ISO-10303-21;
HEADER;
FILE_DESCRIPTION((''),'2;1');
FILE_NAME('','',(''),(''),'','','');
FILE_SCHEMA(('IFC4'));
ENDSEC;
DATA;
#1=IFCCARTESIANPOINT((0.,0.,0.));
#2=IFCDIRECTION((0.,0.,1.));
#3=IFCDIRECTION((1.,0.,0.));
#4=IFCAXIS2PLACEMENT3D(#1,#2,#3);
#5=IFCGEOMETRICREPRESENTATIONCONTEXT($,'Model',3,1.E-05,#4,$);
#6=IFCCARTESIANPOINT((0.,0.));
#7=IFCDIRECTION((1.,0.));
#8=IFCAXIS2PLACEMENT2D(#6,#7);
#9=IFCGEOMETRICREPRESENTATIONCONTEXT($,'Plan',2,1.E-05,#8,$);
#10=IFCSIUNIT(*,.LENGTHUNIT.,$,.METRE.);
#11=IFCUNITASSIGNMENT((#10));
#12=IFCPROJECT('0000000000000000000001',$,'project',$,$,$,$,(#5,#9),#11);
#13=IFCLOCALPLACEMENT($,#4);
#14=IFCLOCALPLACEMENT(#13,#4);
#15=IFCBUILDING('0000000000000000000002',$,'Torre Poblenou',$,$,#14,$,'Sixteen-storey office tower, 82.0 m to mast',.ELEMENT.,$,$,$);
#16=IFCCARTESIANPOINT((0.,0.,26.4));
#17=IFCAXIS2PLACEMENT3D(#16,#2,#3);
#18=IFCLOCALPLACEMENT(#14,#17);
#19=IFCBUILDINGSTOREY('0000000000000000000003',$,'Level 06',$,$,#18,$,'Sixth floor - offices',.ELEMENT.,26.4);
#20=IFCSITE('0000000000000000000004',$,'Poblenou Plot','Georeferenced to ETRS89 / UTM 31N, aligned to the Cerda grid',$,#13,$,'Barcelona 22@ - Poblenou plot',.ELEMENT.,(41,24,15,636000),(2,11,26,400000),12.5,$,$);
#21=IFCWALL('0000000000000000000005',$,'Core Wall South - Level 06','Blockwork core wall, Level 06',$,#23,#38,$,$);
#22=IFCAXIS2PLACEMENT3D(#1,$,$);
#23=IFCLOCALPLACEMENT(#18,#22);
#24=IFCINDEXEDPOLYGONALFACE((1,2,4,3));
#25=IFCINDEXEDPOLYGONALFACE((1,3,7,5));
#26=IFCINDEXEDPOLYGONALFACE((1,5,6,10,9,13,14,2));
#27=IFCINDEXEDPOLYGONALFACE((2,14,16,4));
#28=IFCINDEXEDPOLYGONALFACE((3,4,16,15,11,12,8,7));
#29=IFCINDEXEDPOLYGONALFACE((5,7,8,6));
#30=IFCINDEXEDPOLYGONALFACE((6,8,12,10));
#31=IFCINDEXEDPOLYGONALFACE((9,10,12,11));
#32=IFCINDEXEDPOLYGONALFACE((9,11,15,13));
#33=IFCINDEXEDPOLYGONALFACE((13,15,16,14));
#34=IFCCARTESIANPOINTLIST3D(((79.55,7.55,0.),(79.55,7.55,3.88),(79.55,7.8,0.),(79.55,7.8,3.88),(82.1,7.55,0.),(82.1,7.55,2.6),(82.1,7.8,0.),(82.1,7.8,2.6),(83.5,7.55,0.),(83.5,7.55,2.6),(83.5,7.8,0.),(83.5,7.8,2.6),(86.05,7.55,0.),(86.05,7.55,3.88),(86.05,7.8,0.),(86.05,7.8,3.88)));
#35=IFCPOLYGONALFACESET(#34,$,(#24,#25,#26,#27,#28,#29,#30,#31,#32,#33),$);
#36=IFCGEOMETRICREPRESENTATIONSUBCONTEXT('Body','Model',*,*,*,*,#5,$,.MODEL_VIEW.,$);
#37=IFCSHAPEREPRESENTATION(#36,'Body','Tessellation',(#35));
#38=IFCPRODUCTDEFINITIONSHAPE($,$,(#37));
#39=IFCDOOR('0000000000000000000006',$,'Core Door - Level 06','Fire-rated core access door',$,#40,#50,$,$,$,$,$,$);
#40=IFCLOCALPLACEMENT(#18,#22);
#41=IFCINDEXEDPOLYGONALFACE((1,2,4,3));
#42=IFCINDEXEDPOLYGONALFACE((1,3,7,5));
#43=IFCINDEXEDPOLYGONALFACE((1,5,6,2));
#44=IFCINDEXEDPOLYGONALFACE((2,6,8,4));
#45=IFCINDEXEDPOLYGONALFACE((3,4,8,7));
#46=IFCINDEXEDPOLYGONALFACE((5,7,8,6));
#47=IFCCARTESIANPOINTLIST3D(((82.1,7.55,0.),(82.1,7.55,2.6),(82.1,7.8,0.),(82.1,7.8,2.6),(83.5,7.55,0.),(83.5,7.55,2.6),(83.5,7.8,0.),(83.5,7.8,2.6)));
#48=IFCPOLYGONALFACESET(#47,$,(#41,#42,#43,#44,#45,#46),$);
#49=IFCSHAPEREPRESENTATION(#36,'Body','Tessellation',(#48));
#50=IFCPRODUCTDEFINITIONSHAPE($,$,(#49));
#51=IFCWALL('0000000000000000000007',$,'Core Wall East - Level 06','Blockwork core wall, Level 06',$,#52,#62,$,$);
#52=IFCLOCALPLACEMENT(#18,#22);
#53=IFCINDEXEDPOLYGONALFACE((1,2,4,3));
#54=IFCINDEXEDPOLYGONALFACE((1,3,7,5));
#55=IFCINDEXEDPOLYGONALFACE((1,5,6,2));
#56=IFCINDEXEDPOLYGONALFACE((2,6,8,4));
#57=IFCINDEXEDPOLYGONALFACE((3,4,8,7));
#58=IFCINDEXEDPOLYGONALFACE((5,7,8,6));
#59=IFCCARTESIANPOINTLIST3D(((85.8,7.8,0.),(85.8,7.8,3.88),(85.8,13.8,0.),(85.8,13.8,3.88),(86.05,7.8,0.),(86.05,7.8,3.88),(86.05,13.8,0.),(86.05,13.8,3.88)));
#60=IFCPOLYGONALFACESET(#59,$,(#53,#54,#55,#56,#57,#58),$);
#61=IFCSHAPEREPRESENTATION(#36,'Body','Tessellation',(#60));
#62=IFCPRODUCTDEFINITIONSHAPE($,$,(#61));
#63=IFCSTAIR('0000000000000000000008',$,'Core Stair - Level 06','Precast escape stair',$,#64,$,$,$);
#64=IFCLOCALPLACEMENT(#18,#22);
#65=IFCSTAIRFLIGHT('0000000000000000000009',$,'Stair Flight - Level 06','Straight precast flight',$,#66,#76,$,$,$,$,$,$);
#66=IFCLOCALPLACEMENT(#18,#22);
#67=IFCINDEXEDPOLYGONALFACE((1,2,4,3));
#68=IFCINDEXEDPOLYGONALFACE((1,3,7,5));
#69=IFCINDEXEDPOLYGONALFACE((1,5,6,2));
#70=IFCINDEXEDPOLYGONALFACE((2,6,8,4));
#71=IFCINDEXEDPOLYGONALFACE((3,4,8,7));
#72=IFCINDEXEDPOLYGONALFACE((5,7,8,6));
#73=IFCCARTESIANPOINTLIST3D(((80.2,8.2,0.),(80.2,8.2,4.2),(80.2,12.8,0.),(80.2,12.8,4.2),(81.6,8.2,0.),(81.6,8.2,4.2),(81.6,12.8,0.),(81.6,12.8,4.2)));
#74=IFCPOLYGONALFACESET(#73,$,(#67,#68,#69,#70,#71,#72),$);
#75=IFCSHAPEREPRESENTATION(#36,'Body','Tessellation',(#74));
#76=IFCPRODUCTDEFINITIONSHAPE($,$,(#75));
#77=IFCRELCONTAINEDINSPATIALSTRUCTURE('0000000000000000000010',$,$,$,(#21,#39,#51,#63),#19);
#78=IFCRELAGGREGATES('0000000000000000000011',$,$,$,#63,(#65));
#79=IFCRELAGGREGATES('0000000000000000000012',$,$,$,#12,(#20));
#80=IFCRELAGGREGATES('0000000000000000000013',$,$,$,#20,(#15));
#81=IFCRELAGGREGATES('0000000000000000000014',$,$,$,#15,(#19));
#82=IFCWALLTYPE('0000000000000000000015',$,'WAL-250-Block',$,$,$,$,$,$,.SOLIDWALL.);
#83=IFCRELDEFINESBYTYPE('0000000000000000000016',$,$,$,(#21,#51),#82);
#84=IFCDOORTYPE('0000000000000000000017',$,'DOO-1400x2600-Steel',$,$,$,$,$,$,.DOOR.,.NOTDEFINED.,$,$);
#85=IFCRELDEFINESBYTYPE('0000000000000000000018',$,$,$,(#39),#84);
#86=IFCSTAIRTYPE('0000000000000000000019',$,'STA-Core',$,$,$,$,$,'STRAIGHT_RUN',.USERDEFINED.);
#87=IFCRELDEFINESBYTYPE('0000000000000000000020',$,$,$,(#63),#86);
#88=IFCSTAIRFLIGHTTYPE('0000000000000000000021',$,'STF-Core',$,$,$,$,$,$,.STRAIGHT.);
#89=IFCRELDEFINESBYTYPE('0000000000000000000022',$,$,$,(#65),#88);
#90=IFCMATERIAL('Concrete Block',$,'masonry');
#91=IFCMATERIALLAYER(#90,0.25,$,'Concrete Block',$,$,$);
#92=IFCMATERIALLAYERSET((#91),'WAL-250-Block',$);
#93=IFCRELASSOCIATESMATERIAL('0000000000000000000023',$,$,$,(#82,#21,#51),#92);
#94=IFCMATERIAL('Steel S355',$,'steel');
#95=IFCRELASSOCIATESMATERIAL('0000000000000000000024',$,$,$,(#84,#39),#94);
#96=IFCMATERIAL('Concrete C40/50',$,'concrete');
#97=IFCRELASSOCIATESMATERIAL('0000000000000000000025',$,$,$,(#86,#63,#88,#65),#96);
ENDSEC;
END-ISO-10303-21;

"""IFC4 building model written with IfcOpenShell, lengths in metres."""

from ifc_helpers import new_model, si_unit, frame, origin_with_axes, origin_2d_with_axis, place, context, subcontext, project, spatial, line, indexed_curve, outline, extrude, material, layer, layer_set, layer_usage, type_object, element, fill, aggregate, save


model = new_model("IFC4")

# Units and contexts
model_context = context("Model", 3, precision=1e-05, world=origin_with_axes())
plan_context = context("Plan", 2, precision=1e-05, world=origin_2d_with_axis())
body_context = subcontext(model_context, "Body", "Model", "MODEL_VIEW")
ifc_project = project(units=[si_unit("LENGTHUNIT", "METRE")], contexts=[model_context, plan_context])

# Site, building, storey
site_placement = place(None, origin_with_axes())
site = spatial("IfcSite", under=ifc_project, at=site_placement, Name="Poblenou Plot", Description="Georeferenced to ETRS89 / UTM 31N, aligned to the Cerda grid", LongName="Barcelona 22@ - Poblenou plot", CompositionType="ELEMENT", RefLatitude=(41, 24, 15, 636000), RefLongitude=(2, 11, 26, 400000), RefElevation=12.5)
building_placement = place(site_placement, origin_with_axes())
building = spatial("IfcBuilding", under=site, at=building_placement, Name="Torre Poblenou", LongName="Sixteen-storey office tower, 82.0 m to mast", CompositionType="ELEMENT")
storey_placement = place(building_placement, frame((0.0, 0.0, 26.4), z_axis=(0.0, 0.0, 1.0), x_axis=(1.0, 0.0, 0.0)))
storey = spatial("IfcBuildingStorey", under=building, at=storey_placement, Name="Level 06", LongName="Sixth floor - offices", CompositionType="ELEMENT", Elevation=26.4)

# Shared definitions
ifc_material_1 = material(Name="Concrete C40/50", Category="concrete")

# Wall, opening, door
ifc_material_2 = material(Name="Concrete Block", Category="masonry")
ifc_layer_1 = layer(ifc_material_2, 0.25, Name="Concrete Block")
ifc_layer_set_1 = layer_set([ifc_layer_1], Name="WAL-250-Block")
ifc_layer_usage_1 = layer_usage(ifc_layer_set_1, "AXIS2", "POSITIVE", 0.0)
wall_type = type_object("IfcWallType", Name="WAL-250-Block", PredefinedType="SOLIDWALL", material=ifc_layer_set_1)
wall_1_placement = place(storey_placement, frame((86.05, 7.8, 0.0), z_axis=(0.0, 0.0, 1.0), x_axis=(-1.0, 0.0, 0.0)))
wall_1 = element("IfcWall", 1, at=wall_1_placement, inside=storey, type_object=wall_type, material=ifc_layer_usage_1, Name="Core Wall South - Level 06", Description="Blockwork core wall, Level 06", context=body_context, shape_type="SweptSolid", body=[
    extrude(outline(indexed_curve([(0.0, 0.0), (6.5, 0.0), (6.5, 0.25), (0.0, 0.25)], segments=[line(1, 2, 3, 4, 1)])), origin_with_axes(), (0.0, 0.0, 1.0), 3.88),
])
opening_placement = place(wall_1_placement, frame((2.55, -0.05, 0.0), z_axis=(0.0, 0.0, 1.0), x_axis=(1.0, 0.0, 0.0)))
opening = element("IfcOpeningElement", 2, at=opening_placement, cuts=wall_1, PredefinedType="OPENING", context=body_context, shape_type="SweptSolid", body=[
    extrude(outline(indexed_curve([(0.0, 0.0), (1.4, 0.0), (1.4, 0.35), (0.0, 0.35)], segments=[line(1, 2, 3, 4, 1)])), origin_with_axes(), (0.0, 0.0, 1.0), 2.6),
])
ifc_material_3 = material(Name="Steel S355", Category="steel")
door_type = type_object("IfcDoorType", Name="DOO-1400x2600-Steel", OperationType="NOTDEFINED", PredefinedType="DOOR", material=ifc_material_3)
door_placement = place(storey_placement, frame((83.5, 7.8, 0.0), z_axis=(0.0, 0.0, 1.0), x_axis=(-1.0, 0.0, 0.0)))
door = element("IfcDoor", 3, at=door_placement, inside=storey, type_object=door_type, material=ifc_material_3, Name="Core Door - Level 06", Description="Fire-rated core access door", context=body_context, shape_type="SweptSolid", body=[
    extrude(outline(indexed_curve([(0.0, 0.0), (1.4, 0.0), (1.4, 0.25), (0.0, 0.25)], segments=[line(1, 2, 3, 4, 1)])), origin_with_axes(), (0.0, 0.0, 1.0), 2.6),
])
fill(opening, door)

# Wall
ifc_layer_usage_2 = layer_usage(ifc_layer_set_1, "AXIS2", "POSITIVE", 0.0)
wall_2_placement = place(storey_placement, frame((85.8, 13.8, 0.0), z_axis=(0.0, 0.0, 1.0), x_axis=(0.0, -1.0, 0.0)))
element("IfcWall", 4, at=wall_2_placement, inside=storey, type_object=wall_type, material=ifc_layer_usage_2, Name="Core Wall East - Level 06", Description="Blockwork core wall, Level 06", context=body_context, shape_type="SweptSolid", body=[
    extrude(outline(indexed_curve([(0.0, 0.0), (6.0, 0.0), (6.0, 0.25), (0.0, 0.25)], segments=[line(1, 2, 3, 4, 1)])), origin_with_axes(), (0.0, 0.0, 1.0), 3.88),
])

# Stair, stair flight
stair_type = type_object("IfcStairType", Name="STA-Core", ElementType="STRAIGHT_RUN", PredefinedType="USERDEFINED", material=ifc_material_1)
stair_placement = place(storey_placement, frame((80.2, 8.2, 0.0), z_axis=(0.0, 0.0, 1.0), x_axis=(1.0, 0.0, 0.0)))
stair = element("IfcStair", 5, at=stair_placement, inside=storey, type_object=stair_type, material=ifc_material_1, Name="Core Stair - Level 06", Description="Precast escape stair")
stair_flight_type = type_object("IfcStairFlightType", Name="STF-Core", PredefinedType="STRAIGHT", material=ifc_material_1)
stair_flight_placement = place(stair_placement, origin_with_axes())
stair_flight = element("IfcStairFlight", 6, at=stair_flight_placement, type_object=stair_flight_type, material=ifc_material_1, Name="Stair Flight - Level 06", Description="Straight precast flight", context=body_context, shape_type="SweptSolid", body=[
    extrude(outline(indexed_curve([(0.0, 0.0), (1.4, 0.0), (1.4, 4.6), (0.0, 4.6)], segments=[line(1, 2, 3, 4, 1)])), origin_with_axes(), (0.0, 0.0, 1.0), 4.2),
])
aggregate(stair, [stair_flight])

save(model, "model.ifc")
